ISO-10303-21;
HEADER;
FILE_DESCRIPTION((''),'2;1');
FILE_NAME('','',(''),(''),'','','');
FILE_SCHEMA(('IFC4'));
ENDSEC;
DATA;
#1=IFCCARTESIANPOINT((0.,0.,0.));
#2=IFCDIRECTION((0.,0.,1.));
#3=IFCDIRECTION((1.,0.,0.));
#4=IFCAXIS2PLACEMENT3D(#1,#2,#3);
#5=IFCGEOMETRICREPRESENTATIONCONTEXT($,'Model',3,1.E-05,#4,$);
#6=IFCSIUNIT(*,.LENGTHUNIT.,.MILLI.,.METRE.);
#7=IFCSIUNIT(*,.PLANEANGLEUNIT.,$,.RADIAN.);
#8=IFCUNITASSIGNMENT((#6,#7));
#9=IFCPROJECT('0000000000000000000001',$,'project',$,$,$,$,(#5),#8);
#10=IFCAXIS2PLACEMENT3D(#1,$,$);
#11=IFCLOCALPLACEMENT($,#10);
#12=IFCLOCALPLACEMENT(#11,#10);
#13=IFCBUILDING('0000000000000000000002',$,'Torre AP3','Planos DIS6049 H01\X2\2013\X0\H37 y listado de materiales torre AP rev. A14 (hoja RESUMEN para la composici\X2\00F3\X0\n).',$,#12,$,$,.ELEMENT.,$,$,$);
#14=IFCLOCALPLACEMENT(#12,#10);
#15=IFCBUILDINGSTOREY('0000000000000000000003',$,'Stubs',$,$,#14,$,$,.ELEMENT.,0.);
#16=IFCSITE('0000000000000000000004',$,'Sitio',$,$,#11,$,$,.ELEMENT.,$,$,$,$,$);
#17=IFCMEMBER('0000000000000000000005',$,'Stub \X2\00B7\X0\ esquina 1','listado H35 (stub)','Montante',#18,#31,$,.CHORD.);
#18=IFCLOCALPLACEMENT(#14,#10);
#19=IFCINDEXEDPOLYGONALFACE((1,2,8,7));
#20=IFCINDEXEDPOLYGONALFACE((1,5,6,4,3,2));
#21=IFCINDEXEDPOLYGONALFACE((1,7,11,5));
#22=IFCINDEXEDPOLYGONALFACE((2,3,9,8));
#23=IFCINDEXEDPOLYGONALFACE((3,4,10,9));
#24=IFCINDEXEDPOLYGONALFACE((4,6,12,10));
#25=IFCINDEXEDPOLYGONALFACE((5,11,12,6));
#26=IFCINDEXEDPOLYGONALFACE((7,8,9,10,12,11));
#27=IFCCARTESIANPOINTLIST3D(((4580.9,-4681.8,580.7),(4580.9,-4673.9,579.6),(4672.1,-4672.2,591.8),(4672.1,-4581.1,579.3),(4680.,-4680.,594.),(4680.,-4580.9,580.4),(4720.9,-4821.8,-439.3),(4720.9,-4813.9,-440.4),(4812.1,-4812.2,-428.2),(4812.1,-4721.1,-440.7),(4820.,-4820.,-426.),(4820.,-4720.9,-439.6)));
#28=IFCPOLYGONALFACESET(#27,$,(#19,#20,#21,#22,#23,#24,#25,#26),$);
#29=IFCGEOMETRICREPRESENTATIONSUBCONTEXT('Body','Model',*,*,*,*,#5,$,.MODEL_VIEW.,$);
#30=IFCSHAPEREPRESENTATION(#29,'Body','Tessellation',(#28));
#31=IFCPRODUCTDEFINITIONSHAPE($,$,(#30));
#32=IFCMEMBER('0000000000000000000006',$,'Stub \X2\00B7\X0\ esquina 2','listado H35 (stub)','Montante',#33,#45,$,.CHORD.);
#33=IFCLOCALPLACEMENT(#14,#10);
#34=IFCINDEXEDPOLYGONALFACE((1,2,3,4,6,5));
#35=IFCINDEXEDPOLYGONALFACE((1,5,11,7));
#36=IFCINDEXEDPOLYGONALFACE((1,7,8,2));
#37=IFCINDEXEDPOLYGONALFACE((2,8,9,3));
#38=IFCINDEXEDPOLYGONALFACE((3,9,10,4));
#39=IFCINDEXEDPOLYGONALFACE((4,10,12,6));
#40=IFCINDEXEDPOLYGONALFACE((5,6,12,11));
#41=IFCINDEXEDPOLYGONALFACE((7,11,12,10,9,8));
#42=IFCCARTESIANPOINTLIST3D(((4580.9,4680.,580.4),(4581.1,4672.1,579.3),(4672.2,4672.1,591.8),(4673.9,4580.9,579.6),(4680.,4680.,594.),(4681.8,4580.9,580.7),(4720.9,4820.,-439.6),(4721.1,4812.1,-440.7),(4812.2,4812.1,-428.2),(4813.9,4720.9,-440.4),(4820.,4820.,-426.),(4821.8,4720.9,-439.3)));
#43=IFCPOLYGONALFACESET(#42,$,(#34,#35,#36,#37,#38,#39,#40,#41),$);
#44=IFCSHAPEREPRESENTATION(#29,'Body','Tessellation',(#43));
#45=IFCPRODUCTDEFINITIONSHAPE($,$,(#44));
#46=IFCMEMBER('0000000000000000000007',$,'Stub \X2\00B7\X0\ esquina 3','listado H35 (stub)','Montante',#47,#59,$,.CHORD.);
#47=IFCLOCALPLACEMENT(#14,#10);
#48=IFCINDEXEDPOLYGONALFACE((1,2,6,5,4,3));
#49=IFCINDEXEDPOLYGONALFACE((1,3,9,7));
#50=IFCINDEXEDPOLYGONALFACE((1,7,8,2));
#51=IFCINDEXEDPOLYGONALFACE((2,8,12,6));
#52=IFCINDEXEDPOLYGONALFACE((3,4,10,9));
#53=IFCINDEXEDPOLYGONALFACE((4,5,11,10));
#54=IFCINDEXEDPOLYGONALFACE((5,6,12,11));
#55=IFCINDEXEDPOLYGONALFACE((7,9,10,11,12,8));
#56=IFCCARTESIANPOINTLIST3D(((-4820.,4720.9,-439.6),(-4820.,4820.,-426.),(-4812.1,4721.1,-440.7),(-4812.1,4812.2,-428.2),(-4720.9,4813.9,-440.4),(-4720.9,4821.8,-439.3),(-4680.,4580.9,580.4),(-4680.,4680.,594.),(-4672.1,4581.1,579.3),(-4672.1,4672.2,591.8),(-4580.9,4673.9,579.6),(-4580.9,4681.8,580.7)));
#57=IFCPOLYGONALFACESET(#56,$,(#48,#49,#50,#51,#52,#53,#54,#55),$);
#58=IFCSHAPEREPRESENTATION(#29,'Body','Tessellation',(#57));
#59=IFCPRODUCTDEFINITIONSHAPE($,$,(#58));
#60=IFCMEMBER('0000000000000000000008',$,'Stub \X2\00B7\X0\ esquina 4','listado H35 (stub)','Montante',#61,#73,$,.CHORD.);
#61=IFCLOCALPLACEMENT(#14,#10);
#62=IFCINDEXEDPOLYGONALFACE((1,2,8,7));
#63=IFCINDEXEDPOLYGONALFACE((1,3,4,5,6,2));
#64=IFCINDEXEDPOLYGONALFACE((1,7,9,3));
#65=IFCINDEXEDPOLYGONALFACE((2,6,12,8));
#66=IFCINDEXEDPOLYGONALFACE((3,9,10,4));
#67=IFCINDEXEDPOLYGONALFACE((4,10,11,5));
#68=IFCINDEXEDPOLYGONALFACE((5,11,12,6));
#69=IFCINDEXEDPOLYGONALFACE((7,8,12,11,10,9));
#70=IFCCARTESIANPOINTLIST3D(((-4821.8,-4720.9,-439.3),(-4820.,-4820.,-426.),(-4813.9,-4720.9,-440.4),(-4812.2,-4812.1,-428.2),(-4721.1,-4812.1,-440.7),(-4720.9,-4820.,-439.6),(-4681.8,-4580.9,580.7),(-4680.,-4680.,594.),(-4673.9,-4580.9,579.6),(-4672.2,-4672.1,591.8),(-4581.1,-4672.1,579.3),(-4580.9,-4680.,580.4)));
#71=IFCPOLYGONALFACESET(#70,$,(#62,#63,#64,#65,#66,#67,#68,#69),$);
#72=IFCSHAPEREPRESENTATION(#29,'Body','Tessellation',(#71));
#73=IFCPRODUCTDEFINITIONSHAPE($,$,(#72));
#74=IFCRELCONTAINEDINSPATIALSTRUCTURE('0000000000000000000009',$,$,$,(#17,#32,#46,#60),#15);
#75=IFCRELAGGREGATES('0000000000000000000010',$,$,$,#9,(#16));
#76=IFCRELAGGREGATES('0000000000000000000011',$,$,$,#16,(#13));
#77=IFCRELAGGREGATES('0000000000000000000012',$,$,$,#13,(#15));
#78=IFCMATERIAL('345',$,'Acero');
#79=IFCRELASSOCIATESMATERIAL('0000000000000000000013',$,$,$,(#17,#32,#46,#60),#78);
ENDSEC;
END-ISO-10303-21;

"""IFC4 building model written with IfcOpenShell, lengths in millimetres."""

from ifc_helpers import new_model, si_unit, frame, frame_2d, origin, origin_with_axes, place, context, subcontext, project, spatial, l_section, extrude, material, element, save


model = new_model("IFC4")

# Units and contexts
model_context = context("Model", 3, precision=1e-05, world=origin_with_axes())
body_context = subcontext(model_context, "Body", "Model", "MODEL_VIEW")
ifc_project = project(units=[si_unit("LENGTHUNIT", "METRE", prefix="MILLI"), si_unit("PLANEANGLEUNIT", "RADIAN")], contexts=[model_context])

# Site, building, storey
site_placement = place(None, origin())
site = spatial("IfcSite", under=ifc_project, at=site_placement, Name="Sitio", CompositionType="ELEMENT")
building_placement = place(site_placement, origin())
building = spatial("IfcBuilding", under=site, at=building_placement, Name="Torre AP3", Description="Planos DIS6049 H01–H37 y listado de materiales torre AP rev. A14 (hoja RESUMEN para la composición).", CompositionType="ELEMENT")
storey_placement = place(building_placement, origin())
storey = spatial("IfcBuildingStorey", under=building, at=storey_placement, Name="Stubs", CompositionType="ELEMENT", Elevation=0.0)

# Members
ifc_material = material(Name="345", Category="Acero")
for number, where, z_axis, x_axis, name in (
    (1, (4680.0, -4680.0, 594.0), (0.13474, -0.13474, -0.981677), (-0.990881, -0.018322, -0.133488), "Stub · esquina 1"),
    (2, (4680.0, 4680.0, 594.0), (0.13474, 0.13474, -0.981677), (0.018322, -0.990881, -0.133488), "Stub · esquina 2"),
    (3, (-4680.0, 4680.0, 594.0), (-0.13474, 0.13474, -0.981677), (0.990881, 0.018322, -0.133488), "Stub · esquina 3"),
    (4, (-4680.0, -4680.0, 594.0), (-0.13474, -0.13474, -0.981677), (-0.018322, 0.990881, -0.133488), "Stub · esquina 4"),
):
    element("IfcMember", number, at=place(storey_placement, frame(where, z_axis=z_axis, x_axis=x_axis)), inside=storey, material=ifc_material, Name=name, Description="listado H35 (stub)", ObjectType="Montante", PredefinedType="CHORD", context=body_context, shape_type="SweptSolid", body=[
        extrude(l_section(Depth=100.0, Width=100.0, Thickness=8.0, at=frame_2d((50.0, 50.0))), None, (0.0, 0.0, 1.0), 1039.0),
    ])

save(model, "model.ifc")
